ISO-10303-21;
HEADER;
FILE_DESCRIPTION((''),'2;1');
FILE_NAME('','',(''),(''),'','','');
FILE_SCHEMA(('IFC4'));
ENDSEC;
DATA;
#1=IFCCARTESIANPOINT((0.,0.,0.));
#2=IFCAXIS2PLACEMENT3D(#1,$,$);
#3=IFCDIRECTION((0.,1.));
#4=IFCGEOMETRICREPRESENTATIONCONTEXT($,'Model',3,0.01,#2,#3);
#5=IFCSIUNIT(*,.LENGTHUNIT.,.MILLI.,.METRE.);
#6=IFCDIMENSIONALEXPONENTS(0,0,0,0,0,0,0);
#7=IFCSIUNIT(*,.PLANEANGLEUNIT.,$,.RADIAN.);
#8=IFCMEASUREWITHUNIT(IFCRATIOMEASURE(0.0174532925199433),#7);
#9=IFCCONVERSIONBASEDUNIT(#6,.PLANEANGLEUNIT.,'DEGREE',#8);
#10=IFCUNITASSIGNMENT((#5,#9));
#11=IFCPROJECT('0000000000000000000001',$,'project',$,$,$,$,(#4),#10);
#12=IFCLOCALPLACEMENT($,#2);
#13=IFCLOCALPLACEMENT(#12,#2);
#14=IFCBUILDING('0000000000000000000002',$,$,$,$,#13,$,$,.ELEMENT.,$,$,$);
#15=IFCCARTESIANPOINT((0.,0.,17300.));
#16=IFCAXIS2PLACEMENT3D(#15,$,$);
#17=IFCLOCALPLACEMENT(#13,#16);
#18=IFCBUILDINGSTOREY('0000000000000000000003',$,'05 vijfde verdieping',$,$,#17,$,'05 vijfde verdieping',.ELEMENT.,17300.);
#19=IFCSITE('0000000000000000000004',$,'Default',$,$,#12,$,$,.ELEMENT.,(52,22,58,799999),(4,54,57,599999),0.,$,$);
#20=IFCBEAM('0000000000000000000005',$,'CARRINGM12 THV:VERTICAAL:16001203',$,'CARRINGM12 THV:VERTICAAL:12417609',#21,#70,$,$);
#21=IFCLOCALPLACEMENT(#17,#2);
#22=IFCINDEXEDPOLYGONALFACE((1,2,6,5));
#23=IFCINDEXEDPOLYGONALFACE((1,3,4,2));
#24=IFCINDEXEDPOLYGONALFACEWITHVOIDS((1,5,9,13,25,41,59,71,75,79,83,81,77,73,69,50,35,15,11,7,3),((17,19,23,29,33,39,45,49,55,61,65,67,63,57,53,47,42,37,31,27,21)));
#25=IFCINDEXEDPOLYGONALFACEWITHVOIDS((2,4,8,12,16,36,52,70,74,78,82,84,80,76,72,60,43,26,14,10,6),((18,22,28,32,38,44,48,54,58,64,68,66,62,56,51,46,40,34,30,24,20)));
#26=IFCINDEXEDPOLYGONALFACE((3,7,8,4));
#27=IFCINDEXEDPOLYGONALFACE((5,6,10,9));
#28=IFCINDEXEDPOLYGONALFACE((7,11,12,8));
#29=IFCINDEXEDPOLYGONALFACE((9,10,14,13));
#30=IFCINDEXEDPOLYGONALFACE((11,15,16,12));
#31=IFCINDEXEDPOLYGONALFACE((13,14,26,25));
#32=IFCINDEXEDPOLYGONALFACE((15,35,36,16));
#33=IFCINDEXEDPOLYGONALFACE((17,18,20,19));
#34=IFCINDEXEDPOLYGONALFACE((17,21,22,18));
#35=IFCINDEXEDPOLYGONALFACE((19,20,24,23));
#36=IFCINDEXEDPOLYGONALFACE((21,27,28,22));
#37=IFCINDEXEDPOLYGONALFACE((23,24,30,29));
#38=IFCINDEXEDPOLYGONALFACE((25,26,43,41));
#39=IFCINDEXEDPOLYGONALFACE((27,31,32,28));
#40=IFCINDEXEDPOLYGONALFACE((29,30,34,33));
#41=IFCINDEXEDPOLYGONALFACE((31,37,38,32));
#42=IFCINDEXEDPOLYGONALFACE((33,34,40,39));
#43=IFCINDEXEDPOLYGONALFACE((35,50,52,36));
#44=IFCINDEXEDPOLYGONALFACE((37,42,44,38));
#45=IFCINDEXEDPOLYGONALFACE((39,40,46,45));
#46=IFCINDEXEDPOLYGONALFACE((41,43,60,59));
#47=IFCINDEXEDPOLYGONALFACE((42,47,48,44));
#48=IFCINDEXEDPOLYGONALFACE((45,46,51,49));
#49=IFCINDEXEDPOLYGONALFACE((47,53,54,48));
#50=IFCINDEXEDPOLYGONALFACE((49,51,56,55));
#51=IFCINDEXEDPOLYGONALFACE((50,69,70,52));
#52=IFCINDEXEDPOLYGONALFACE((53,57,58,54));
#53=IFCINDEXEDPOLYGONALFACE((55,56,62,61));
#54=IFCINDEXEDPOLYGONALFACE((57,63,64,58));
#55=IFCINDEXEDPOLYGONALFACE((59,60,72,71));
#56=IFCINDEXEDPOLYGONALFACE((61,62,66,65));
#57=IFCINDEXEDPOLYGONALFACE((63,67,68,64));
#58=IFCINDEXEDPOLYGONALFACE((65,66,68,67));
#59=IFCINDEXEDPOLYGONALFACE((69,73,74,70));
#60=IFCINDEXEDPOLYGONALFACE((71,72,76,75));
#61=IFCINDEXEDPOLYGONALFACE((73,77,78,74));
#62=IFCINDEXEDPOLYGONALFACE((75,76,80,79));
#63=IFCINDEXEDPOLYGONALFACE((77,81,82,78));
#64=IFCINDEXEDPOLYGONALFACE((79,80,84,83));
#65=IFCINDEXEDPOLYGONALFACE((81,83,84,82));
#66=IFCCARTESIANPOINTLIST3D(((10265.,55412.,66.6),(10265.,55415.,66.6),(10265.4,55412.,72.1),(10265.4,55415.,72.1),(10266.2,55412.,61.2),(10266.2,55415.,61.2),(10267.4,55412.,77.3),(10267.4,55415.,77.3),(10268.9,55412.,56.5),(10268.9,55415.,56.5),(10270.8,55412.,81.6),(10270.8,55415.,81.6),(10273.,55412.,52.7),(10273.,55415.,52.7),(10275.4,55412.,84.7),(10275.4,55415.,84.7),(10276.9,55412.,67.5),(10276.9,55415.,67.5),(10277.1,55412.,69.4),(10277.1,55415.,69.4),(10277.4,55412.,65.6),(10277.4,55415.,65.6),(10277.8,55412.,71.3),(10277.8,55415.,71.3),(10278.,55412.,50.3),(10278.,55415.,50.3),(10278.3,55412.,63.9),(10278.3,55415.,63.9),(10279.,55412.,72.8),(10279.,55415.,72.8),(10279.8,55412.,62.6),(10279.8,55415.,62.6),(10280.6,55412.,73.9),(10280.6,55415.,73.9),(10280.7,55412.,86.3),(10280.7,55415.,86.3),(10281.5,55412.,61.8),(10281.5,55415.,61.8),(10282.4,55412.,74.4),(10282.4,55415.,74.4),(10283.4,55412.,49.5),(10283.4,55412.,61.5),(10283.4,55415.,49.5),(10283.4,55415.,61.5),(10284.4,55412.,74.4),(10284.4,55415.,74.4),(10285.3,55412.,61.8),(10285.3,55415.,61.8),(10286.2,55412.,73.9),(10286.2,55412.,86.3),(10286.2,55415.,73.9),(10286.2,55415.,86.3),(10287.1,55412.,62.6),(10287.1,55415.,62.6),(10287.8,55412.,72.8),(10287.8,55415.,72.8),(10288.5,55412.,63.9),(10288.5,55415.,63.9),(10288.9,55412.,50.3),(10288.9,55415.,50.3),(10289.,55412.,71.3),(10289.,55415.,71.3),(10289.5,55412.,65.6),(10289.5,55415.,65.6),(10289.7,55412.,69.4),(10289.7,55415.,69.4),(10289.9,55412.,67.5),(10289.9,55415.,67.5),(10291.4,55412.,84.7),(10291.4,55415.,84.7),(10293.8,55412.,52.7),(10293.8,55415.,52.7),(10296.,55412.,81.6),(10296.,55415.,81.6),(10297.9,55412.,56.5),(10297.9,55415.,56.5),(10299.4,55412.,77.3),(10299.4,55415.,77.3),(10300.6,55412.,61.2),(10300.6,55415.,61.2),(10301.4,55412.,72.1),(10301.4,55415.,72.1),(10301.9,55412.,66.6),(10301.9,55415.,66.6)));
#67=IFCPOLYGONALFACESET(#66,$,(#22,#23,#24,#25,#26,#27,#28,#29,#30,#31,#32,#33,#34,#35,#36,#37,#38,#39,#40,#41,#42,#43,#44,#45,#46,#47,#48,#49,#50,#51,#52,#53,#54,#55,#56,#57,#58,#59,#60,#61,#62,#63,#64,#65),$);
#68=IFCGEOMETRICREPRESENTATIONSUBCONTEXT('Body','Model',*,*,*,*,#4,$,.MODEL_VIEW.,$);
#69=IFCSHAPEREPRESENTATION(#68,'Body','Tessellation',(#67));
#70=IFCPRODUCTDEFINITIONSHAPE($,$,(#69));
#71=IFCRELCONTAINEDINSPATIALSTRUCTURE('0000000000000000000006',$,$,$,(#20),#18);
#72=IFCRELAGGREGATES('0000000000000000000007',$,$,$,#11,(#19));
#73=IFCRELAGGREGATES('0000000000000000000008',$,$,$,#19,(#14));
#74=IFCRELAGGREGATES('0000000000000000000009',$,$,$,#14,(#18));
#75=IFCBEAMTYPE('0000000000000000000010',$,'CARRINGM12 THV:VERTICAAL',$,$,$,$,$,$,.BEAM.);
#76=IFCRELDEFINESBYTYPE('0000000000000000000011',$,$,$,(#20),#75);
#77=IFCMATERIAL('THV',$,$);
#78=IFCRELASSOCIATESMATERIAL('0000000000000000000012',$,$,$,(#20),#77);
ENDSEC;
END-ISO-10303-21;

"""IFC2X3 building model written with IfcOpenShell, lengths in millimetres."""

from ifc_helpers import new_model, entity, si_unit, converted_unit, direction, frame, origin, origin_2d_with_axis, place, context, subcontext, project, spatial, hollow_circle, extrude, material, type_object, element, save


model = new_model("IFC2X3")

# Units and contexts
model_context = context("Model", 3, precision=0.01, world=origin(), true_north=direction((0.0, 1.0)))
body_context = subcontext(model_context, "Body", "Model", "MODEL_VIEW")
ifc_project = project(units=[si_unit("LENGTHUNIT", "METRE", prefix="MILLI"), converted_unit("PLANEANGLEUNIT", "DEGREE", entity("IfcRatioMeasure", 0.0174532925199433), si_unit("PLANEANGLEUNIT", "RADIAN"), dimensions=[0, 0, 0, 0, 0, 0, 0])], contexts=[model_context])

# Site, building, storey
site_placement = place(None, origin())
site = spatial("IfcSite", under=ifc_project, at=site_placement, Name="Default", CompositionType="ELEMENT", RefLatitude=(52, 22, 58, 799999), RefLongitude=(4, 54, 57, 599999), RefElevation=0.0)
building_placement = place(site_placement, origin())
building = spatial("IfcBuilding", under=site, at=building_placement, CompositionType="ELEMENT")
storey_placement = place(building_placement, frame((0.0, 0.0, 17300.0)))
storey = spatial("IfcBuildingStorey", under=building, at=storey_placement, Name="05 vijfde verdieping", LongName="05 vijfde verdieping", CompositionType="ELEMENT", Elevation=17300.0)

# Beam
ifc_material_1 = material(Name="THV")
beam_type_1 = type_object("IfcBeamType", Name="CARRINGM12 THV:VERTICAAL", PredefinedType="BEAM")
beam_1_placement = place(storey_placement, origin())
element("IfcBeam", 1, at=beam_1_placement, inside=storey, type_object=beam_type_1, material=ifc_material_1, Name="CARRINGM12 THV:VERTICAAL:16001203", ObjectType="CARRINGM12 THV:VERTICAAL:12417609", context=body_context, shape_type="SweptSolid", body=[
    extrude(hollow_circle(Radius=18.5, WallThickness=12.0, at=origin_2d_with_axis()), frame((10283.4, 55412.0, 68.0), z_axis=(0.0, 1.0, 0.0), x_axis=(0.0, 0.0, -1.0)), (0.0, 0.0, 1.0), 3.0),
])

save(model, "model.ifc")
